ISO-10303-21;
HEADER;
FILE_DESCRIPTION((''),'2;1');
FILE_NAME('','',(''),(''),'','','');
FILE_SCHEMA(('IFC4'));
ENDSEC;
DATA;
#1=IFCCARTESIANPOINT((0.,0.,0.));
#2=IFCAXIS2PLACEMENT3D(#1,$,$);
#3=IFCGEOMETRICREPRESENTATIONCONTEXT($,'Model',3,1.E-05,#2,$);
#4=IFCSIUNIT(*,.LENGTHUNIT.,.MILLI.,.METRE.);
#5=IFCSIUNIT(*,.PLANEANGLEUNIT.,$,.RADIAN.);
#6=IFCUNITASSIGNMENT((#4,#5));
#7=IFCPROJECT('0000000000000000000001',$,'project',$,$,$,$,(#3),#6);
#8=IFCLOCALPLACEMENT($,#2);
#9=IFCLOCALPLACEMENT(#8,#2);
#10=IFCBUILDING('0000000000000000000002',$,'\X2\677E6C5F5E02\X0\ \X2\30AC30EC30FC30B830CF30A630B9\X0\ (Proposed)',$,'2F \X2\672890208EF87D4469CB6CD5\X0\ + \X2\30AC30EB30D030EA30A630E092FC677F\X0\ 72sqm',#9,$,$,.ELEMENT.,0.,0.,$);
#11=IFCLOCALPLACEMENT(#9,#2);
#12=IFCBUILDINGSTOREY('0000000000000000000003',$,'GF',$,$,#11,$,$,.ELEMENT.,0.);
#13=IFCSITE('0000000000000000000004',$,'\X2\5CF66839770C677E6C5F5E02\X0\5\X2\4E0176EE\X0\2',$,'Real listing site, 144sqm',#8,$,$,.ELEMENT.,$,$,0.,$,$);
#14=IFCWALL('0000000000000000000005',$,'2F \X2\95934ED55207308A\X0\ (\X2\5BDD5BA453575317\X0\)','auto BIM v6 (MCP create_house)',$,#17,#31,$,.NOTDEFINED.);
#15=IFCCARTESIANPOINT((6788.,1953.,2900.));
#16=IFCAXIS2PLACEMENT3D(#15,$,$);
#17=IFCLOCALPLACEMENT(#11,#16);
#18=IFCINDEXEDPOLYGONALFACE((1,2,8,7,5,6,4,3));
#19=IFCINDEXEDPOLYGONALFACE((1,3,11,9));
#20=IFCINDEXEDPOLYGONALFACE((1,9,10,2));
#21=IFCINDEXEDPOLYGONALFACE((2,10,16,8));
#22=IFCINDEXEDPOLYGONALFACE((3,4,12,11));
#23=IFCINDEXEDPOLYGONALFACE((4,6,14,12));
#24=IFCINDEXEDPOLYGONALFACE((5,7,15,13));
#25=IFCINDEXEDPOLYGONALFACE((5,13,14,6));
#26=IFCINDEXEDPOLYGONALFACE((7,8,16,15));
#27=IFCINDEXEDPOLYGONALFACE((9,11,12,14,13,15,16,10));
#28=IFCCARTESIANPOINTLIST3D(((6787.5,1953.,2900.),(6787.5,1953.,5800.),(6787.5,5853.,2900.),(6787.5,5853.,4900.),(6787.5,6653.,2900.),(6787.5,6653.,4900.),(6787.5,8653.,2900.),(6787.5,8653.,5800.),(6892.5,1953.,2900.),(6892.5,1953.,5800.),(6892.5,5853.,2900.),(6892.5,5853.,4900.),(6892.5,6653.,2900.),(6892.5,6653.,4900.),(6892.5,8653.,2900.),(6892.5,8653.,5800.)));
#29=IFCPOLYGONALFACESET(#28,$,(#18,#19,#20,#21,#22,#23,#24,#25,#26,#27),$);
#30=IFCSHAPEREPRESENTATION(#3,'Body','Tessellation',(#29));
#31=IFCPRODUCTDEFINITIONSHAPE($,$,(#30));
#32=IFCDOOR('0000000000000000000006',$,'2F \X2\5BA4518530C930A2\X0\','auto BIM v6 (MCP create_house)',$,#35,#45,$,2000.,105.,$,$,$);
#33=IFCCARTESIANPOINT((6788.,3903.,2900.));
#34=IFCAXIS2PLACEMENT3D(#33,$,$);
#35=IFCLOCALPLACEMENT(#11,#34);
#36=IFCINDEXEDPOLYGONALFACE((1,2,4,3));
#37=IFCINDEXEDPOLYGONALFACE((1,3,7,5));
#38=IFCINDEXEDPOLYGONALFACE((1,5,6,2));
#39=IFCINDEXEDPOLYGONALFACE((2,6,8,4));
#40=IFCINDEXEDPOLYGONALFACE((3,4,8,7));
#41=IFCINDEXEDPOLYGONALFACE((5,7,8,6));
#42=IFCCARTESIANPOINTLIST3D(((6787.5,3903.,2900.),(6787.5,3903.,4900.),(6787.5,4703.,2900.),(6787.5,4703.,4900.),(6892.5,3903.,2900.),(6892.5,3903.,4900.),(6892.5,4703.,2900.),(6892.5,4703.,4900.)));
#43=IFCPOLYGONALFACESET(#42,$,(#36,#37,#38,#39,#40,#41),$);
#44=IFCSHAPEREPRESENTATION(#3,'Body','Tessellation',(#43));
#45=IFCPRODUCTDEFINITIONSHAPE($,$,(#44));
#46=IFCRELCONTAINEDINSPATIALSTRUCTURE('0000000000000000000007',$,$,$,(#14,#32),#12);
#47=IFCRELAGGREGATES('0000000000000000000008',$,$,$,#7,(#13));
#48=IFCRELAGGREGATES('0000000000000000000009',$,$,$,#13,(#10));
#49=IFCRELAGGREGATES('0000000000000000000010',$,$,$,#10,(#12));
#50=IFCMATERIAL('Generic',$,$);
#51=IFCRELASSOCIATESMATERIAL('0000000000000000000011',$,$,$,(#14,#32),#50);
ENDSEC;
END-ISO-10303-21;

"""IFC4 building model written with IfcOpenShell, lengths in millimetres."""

from ifc_helpers import new_model, si_unit, frame, frame_2d, origin, place, context, project, spatial, rectangle, extrude, material, element, fill, save


model = new_model("IFC4")

# Units and contexts
model_context = context("Model", 3, precision=1e-05, world=origin())
ifc_project = project(units=[si_unit("LENGTHUNIT", "METRE", prefix="MILLI"), si_unit("PLANEANGLEUNIT", "RADIAN")], contexts=[model_context])

# Site, building, storey
site_placement = place(None, origin())
site = spatial("IfcSite", under=ifc_project, at=site_placement, Name="島根県松江市5丁目2", ObjectType="Real listing site, 144sqm", CompositionType="ELEMENT", RefElevation=0.0)
building_placement = place(site_placement, origin())
building = spatial("IfcBuilding", under=site, at=building_placement, Name="松江市 ガレージハウス (Proposed)", ObjectType="2F 木造軸組構法 + ガルバリウム鋼板 72sqm", CompositionType="ELEMENT", ElevationOfRefHeight=0.0, ElevationOfTerrain=0.0)
storey_placement = place(building_placement, origin())
storey = spatial("IfcBuildingStorey", under=building, at=storey_placement, Name="GF", CompositionType="ELEMENT", Elevation=0.0)

# Shared definitions
ifc_material = material(Name="Generic")

# Wall, opening, door
wall_1_placement = place(storey_placement, frame((6788.0, 1953.0, 2900.0)))
wall_1 = element("IfcWall", 1, at=wall_1_placement, inside=storey, material=ifc_material, Name="2F 間仕切り (寝室南北)", Description="auto BIM v6 (MCP create_house)", PredefinedType="NOTDEFINED", context=model_context, shape_type="SweptSolid", body=[
    extrude(rectangle(XDim=105.0, YDim=6700.0, at=frame_2d((52.0, 3350.0))), frame((6788.0, 1953.0, 2900.0)), (0.0, 0.0, 1.0), 2900.0),
])
opening_1_placement = place(storey_placement, frame((6788.0, 3903.0, 2900.0)))
opening_1 = element("IfcOpeningElement", 2, at=opening_1_placement, cuts=wall_1, PredefinedType="NOTDEFINED", context=model_context, shape_type="SweptSolid", body=[
    extrude(rectangle(XDim=105.0, YDim=800.0, at=frame_2d((52.0, 400.0))), frame((6788.0, 3903.0, 2900.0)), (0.0, 0.0, 1.0), 2000.0),
])
door_placement = place(storey_placement, frame((6788.0, 3903.0, 2900.0)))
door = element("IfcDoor", 3, at=door_placement, inside=storey, material=ifc_material, Name="2F 室内ドア", Description="auto BIM v6 (MCP create_house)", OverallHeight=2000.0, OverallWidth=105.0, context=model_context, shape_type="SweptSolid", body=[
    extrude(rectangle(XDim=105.0, YDim=800.0, at=frame_2d((52.0, 400.0))), frame((6788.0, 3903.0, 2900.0)), (0.0, 0.0, 1.0), 2000.0),
])
fill(opening_1, door)

save(model, "model.ifc")
